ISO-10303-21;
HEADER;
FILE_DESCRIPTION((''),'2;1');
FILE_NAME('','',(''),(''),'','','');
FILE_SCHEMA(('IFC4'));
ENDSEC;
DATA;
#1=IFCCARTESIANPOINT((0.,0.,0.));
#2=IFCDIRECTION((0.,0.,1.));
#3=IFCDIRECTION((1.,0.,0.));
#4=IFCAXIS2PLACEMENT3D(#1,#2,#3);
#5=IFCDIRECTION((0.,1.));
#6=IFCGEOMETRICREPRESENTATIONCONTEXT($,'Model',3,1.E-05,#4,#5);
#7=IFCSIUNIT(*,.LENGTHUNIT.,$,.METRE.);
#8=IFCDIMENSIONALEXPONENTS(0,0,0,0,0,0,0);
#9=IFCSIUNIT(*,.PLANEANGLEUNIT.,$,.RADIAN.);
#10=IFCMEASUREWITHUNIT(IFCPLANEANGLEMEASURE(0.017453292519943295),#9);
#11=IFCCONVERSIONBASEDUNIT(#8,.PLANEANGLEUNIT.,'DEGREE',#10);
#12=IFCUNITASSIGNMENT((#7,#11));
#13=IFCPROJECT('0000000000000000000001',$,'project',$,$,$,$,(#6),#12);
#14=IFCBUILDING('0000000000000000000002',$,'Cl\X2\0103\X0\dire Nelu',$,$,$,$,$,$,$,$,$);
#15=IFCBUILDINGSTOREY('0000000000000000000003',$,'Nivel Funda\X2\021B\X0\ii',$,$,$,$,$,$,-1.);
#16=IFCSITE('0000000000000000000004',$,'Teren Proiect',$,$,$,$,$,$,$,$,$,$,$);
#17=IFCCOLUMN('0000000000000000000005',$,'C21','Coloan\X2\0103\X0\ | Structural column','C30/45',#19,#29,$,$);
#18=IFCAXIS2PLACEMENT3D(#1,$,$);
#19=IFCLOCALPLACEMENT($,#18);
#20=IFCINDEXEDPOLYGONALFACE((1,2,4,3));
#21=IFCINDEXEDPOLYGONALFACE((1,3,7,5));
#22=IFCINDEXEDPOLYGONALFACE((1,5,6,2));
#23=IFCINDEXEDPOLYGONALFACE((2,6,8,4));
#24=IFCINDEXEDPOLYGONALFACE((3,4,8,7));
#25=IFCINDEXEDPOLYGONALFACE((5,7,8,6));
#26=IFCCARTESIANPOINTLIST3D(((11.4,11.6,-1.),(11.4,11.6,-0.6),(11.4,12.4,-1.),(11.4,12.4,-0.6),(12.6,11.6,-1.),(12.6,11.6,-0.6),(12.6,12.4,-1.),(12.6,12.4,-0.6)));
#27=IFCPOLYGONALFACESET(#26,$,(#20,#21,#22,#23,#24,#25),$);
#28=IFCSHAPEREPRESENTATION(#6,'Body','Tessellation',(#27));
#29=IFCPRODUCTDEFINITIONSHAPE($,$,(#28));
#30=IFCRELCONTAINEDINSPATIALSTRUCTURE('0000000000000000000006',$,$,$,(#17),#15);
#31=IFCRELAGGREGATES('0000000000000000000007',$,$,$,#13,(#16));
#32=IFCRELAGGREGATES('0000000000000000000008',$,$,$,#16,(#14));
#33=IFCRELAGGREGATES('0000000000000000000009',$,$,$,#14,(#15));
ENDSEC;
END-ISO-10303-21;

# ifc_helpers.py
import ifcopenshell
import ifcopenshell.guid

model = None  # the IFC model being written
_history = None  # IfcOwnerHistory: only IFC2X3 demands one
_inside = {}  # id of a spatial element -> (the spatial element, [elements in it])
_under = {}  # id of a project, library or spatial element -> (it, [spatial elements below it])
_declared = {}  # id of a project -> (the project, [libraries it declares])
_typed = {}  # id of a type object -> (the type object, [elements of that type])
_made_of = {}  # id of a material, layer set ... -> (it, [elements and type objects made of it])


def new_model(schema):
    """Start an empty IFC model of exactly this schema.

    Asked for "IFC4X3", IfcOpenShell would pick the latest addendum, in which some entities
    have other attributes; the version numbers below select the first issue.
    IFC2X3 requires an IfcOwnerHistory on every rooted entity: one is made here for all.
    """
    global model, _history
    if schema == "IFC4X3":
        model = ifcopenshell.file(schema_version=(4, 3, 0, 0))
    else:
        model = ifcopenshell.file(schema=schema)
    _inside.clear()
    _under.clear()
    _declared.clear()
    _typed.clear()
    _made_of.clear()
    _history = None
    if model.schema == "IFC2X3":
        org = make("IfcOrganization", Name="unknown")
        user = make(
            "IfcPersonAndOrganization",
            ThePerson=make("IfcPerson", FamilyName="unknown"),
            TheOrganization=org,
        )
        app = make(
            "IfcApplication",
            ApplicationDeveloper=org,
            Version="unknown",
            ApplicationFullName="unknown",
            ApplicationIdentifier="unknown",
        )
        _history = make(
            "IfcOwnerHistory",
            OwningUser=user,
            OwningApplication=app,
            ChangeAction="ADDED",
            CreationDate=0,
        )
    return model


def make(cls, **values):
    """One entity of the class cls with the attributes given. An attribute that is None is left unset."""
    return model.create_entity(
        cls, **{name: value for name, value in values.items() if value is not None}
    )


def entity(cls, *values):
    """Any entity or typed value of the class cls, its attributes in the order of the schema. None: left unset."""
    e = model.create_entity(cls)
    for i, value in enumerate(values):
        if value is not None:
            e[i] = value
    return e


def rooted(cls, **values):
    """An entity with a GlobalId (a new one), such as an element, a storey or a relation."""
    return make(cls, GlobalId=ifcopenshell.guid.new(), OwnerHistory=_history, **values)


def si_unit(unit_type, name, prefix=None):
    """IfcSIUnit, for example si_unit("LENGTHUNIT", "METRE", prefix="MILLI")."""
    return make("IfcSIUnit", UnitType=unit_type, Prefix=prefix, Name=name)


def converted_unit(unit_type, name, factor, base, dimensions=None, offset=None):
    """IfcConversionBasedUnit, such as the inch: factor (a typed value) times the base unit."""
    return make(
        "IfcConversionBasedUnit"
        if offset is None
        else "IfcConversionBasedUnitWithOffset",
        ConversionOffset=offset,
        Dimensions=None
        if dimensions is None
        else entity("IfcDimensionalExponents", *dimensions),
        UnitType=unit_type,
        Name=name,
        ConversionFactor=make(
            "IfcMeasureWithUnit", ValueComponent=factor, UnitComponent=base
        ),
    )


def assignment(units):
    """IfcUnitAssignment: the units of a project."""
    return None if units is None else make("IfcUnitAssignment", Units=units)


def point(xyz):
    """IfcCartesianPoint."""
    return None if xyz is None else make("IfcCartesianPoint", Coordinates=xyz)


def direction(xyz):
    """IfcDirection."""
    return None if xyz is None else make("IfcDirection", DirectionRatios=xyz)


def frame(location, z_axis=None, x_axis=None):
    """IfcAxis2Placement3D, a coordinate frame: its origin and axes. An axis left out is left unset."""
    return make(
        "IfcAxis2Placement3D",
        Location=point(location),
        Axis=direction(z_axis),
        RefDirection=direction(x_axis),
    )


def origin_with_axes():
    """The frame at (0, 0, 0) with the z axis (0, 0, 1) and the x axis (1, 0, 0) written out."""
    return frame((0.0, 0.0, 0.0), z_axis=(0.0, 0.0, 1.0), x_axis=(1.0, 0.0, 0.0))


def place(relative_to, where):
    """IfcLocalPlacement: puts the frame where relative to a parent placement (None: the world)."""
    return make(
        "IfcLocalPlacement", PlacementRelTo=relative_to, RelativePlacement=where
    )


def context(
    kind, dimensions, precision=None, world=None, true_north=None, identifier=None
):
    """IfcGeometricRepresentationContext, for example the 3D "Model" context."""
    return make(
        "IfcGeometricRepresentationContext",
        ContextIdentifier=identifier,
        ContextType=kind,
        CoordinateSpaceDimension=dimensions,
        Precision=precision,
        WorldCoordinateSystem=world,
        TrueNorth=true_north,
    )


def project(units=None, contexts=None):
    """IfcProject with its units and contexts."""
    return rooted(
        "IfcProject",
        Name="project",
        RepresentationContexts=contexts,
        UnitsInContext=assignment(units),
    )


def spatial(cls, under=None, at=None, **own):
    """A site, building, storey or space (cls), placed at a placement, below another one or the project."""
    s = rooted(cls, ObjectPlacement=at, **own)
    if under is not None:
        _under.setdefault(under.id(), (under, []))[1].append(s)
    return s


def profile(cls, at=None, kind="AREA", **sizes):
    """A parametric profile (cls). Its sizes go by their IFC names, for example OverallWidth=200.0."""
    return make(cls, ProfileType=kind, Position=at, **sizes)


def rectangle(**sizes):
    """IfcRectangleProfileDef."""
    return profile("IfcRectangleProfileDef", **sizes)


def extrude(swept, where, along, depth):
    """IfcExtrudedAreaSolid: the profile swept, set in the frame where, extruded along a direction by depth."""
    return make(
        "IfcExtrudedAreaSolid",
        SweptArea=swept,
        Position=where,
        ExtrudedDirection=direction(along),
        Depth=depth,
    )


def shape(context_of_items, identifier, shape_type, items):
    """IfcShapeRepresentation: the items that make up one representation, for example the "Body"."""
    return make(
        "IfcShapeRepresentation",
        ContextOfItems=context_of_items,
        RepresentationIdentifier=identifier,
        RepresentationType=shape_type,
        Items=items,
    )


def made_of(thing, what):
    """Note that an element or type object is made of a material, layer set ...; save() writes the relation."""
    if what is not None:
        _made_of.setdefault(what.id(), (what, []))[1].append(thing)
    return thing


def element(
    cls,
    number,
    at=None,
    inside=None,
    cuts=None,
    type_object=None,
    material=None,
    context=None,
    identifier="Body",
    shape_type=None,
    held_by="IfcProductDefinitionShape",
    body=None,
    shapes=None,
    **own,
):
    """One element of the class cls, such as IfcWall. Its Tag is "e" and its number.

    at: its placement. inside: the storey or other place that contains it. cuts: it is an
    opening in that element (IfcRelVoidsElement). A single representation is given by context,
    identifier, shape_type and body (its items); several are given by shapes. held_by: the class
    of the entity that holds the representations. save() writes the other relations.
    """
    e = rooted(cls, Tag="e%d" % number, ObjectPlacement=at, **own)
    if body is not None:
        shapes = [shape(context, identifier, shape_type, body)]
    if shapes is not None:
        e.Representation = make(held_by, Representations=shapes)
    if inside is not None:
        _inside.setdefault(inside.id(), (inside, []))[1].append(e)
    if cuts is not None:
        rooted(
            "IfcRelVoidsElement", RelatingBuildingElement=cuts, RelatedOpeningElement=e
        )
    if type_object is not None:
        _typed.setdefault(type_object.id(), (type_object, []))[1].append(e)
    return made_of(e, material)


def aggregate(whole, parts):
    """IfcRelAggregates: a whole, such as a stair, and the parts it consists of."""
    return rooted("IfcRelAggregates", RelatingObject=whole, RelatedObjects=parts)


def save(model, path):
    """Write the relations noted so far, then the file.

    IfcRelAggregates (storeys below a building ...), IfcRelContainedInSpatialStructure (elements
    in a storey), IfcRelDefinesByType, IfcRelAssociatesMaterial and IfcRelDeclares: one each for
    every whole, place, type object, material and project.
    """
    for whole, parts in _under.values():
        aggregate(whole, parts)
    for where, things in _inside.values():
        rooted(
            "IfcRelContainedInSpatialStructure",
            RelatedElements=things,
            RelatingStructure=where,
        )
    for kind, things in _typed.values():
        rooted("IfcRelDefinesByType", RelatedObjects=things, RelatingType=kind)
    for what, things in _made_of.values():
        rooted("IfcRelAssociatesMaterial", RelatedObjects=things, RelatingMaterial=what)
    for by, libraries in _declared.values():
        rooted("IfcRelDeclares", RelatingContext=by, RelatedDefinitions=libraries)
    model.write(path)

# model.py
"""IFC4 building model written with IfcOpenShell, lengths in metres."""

from ifc_helpers import new_model, entity, si_unit, converted_unit, direction, frame, origin_with_axes, place, context, project, spatial, rectangle, extrude, element, save


model = new_model("IFC4")

# Units and contexts
model_context = context("Model", 3, precision=1e-05, world=origin_with_axes(), true_north=direction((0.0, 1.0)))
ifc_project = project(units=[si_unit("LENGTHUNIT", "METRE"), converted_unit("PLANEANGLEUNIT", "DEGREE", entity("IfcPlaneAngleMeasure", 0.017453292519943295), si_unit("PLANEANGLEUNIT", "RADIAN"), dimensions=[0, 0, 0, 0, 0, 0, 0])], contexts=[model_context])

# Site, building, storey
site = spatial("IfcSite", under=ifc_project, Name="Teren Proiect")
building = spatial("IfcBuilding", under=site, Name="Clădire Nelu")
storey = spatial("IfcBuildingStorey", under=building, Name="Nivel Fundații", Elevation=-1.0)

# Column
for number, where, z_axis, x_axis, name in (
    (1, (12.0, 12.0, -1.0), (0.0, 0.0, 1.0), (1.0, 0.0, 0.0), "C21"),
):
    element("IfcColumn", number, at=place(None, frame(where, z_axis=z_axis, x_axis=x_axis)), inside=storey, Name=name, Description="Coloană | Structural column", ObjectType="C30/45", context=model_context, shape_type="SweptSolid", body=[
        extrude(rectangle(XDim=1.2, YDim=0.8), None, (0.0, 0.0, 1.0), 0.4),
    ])

save(model, "model.ifc")
